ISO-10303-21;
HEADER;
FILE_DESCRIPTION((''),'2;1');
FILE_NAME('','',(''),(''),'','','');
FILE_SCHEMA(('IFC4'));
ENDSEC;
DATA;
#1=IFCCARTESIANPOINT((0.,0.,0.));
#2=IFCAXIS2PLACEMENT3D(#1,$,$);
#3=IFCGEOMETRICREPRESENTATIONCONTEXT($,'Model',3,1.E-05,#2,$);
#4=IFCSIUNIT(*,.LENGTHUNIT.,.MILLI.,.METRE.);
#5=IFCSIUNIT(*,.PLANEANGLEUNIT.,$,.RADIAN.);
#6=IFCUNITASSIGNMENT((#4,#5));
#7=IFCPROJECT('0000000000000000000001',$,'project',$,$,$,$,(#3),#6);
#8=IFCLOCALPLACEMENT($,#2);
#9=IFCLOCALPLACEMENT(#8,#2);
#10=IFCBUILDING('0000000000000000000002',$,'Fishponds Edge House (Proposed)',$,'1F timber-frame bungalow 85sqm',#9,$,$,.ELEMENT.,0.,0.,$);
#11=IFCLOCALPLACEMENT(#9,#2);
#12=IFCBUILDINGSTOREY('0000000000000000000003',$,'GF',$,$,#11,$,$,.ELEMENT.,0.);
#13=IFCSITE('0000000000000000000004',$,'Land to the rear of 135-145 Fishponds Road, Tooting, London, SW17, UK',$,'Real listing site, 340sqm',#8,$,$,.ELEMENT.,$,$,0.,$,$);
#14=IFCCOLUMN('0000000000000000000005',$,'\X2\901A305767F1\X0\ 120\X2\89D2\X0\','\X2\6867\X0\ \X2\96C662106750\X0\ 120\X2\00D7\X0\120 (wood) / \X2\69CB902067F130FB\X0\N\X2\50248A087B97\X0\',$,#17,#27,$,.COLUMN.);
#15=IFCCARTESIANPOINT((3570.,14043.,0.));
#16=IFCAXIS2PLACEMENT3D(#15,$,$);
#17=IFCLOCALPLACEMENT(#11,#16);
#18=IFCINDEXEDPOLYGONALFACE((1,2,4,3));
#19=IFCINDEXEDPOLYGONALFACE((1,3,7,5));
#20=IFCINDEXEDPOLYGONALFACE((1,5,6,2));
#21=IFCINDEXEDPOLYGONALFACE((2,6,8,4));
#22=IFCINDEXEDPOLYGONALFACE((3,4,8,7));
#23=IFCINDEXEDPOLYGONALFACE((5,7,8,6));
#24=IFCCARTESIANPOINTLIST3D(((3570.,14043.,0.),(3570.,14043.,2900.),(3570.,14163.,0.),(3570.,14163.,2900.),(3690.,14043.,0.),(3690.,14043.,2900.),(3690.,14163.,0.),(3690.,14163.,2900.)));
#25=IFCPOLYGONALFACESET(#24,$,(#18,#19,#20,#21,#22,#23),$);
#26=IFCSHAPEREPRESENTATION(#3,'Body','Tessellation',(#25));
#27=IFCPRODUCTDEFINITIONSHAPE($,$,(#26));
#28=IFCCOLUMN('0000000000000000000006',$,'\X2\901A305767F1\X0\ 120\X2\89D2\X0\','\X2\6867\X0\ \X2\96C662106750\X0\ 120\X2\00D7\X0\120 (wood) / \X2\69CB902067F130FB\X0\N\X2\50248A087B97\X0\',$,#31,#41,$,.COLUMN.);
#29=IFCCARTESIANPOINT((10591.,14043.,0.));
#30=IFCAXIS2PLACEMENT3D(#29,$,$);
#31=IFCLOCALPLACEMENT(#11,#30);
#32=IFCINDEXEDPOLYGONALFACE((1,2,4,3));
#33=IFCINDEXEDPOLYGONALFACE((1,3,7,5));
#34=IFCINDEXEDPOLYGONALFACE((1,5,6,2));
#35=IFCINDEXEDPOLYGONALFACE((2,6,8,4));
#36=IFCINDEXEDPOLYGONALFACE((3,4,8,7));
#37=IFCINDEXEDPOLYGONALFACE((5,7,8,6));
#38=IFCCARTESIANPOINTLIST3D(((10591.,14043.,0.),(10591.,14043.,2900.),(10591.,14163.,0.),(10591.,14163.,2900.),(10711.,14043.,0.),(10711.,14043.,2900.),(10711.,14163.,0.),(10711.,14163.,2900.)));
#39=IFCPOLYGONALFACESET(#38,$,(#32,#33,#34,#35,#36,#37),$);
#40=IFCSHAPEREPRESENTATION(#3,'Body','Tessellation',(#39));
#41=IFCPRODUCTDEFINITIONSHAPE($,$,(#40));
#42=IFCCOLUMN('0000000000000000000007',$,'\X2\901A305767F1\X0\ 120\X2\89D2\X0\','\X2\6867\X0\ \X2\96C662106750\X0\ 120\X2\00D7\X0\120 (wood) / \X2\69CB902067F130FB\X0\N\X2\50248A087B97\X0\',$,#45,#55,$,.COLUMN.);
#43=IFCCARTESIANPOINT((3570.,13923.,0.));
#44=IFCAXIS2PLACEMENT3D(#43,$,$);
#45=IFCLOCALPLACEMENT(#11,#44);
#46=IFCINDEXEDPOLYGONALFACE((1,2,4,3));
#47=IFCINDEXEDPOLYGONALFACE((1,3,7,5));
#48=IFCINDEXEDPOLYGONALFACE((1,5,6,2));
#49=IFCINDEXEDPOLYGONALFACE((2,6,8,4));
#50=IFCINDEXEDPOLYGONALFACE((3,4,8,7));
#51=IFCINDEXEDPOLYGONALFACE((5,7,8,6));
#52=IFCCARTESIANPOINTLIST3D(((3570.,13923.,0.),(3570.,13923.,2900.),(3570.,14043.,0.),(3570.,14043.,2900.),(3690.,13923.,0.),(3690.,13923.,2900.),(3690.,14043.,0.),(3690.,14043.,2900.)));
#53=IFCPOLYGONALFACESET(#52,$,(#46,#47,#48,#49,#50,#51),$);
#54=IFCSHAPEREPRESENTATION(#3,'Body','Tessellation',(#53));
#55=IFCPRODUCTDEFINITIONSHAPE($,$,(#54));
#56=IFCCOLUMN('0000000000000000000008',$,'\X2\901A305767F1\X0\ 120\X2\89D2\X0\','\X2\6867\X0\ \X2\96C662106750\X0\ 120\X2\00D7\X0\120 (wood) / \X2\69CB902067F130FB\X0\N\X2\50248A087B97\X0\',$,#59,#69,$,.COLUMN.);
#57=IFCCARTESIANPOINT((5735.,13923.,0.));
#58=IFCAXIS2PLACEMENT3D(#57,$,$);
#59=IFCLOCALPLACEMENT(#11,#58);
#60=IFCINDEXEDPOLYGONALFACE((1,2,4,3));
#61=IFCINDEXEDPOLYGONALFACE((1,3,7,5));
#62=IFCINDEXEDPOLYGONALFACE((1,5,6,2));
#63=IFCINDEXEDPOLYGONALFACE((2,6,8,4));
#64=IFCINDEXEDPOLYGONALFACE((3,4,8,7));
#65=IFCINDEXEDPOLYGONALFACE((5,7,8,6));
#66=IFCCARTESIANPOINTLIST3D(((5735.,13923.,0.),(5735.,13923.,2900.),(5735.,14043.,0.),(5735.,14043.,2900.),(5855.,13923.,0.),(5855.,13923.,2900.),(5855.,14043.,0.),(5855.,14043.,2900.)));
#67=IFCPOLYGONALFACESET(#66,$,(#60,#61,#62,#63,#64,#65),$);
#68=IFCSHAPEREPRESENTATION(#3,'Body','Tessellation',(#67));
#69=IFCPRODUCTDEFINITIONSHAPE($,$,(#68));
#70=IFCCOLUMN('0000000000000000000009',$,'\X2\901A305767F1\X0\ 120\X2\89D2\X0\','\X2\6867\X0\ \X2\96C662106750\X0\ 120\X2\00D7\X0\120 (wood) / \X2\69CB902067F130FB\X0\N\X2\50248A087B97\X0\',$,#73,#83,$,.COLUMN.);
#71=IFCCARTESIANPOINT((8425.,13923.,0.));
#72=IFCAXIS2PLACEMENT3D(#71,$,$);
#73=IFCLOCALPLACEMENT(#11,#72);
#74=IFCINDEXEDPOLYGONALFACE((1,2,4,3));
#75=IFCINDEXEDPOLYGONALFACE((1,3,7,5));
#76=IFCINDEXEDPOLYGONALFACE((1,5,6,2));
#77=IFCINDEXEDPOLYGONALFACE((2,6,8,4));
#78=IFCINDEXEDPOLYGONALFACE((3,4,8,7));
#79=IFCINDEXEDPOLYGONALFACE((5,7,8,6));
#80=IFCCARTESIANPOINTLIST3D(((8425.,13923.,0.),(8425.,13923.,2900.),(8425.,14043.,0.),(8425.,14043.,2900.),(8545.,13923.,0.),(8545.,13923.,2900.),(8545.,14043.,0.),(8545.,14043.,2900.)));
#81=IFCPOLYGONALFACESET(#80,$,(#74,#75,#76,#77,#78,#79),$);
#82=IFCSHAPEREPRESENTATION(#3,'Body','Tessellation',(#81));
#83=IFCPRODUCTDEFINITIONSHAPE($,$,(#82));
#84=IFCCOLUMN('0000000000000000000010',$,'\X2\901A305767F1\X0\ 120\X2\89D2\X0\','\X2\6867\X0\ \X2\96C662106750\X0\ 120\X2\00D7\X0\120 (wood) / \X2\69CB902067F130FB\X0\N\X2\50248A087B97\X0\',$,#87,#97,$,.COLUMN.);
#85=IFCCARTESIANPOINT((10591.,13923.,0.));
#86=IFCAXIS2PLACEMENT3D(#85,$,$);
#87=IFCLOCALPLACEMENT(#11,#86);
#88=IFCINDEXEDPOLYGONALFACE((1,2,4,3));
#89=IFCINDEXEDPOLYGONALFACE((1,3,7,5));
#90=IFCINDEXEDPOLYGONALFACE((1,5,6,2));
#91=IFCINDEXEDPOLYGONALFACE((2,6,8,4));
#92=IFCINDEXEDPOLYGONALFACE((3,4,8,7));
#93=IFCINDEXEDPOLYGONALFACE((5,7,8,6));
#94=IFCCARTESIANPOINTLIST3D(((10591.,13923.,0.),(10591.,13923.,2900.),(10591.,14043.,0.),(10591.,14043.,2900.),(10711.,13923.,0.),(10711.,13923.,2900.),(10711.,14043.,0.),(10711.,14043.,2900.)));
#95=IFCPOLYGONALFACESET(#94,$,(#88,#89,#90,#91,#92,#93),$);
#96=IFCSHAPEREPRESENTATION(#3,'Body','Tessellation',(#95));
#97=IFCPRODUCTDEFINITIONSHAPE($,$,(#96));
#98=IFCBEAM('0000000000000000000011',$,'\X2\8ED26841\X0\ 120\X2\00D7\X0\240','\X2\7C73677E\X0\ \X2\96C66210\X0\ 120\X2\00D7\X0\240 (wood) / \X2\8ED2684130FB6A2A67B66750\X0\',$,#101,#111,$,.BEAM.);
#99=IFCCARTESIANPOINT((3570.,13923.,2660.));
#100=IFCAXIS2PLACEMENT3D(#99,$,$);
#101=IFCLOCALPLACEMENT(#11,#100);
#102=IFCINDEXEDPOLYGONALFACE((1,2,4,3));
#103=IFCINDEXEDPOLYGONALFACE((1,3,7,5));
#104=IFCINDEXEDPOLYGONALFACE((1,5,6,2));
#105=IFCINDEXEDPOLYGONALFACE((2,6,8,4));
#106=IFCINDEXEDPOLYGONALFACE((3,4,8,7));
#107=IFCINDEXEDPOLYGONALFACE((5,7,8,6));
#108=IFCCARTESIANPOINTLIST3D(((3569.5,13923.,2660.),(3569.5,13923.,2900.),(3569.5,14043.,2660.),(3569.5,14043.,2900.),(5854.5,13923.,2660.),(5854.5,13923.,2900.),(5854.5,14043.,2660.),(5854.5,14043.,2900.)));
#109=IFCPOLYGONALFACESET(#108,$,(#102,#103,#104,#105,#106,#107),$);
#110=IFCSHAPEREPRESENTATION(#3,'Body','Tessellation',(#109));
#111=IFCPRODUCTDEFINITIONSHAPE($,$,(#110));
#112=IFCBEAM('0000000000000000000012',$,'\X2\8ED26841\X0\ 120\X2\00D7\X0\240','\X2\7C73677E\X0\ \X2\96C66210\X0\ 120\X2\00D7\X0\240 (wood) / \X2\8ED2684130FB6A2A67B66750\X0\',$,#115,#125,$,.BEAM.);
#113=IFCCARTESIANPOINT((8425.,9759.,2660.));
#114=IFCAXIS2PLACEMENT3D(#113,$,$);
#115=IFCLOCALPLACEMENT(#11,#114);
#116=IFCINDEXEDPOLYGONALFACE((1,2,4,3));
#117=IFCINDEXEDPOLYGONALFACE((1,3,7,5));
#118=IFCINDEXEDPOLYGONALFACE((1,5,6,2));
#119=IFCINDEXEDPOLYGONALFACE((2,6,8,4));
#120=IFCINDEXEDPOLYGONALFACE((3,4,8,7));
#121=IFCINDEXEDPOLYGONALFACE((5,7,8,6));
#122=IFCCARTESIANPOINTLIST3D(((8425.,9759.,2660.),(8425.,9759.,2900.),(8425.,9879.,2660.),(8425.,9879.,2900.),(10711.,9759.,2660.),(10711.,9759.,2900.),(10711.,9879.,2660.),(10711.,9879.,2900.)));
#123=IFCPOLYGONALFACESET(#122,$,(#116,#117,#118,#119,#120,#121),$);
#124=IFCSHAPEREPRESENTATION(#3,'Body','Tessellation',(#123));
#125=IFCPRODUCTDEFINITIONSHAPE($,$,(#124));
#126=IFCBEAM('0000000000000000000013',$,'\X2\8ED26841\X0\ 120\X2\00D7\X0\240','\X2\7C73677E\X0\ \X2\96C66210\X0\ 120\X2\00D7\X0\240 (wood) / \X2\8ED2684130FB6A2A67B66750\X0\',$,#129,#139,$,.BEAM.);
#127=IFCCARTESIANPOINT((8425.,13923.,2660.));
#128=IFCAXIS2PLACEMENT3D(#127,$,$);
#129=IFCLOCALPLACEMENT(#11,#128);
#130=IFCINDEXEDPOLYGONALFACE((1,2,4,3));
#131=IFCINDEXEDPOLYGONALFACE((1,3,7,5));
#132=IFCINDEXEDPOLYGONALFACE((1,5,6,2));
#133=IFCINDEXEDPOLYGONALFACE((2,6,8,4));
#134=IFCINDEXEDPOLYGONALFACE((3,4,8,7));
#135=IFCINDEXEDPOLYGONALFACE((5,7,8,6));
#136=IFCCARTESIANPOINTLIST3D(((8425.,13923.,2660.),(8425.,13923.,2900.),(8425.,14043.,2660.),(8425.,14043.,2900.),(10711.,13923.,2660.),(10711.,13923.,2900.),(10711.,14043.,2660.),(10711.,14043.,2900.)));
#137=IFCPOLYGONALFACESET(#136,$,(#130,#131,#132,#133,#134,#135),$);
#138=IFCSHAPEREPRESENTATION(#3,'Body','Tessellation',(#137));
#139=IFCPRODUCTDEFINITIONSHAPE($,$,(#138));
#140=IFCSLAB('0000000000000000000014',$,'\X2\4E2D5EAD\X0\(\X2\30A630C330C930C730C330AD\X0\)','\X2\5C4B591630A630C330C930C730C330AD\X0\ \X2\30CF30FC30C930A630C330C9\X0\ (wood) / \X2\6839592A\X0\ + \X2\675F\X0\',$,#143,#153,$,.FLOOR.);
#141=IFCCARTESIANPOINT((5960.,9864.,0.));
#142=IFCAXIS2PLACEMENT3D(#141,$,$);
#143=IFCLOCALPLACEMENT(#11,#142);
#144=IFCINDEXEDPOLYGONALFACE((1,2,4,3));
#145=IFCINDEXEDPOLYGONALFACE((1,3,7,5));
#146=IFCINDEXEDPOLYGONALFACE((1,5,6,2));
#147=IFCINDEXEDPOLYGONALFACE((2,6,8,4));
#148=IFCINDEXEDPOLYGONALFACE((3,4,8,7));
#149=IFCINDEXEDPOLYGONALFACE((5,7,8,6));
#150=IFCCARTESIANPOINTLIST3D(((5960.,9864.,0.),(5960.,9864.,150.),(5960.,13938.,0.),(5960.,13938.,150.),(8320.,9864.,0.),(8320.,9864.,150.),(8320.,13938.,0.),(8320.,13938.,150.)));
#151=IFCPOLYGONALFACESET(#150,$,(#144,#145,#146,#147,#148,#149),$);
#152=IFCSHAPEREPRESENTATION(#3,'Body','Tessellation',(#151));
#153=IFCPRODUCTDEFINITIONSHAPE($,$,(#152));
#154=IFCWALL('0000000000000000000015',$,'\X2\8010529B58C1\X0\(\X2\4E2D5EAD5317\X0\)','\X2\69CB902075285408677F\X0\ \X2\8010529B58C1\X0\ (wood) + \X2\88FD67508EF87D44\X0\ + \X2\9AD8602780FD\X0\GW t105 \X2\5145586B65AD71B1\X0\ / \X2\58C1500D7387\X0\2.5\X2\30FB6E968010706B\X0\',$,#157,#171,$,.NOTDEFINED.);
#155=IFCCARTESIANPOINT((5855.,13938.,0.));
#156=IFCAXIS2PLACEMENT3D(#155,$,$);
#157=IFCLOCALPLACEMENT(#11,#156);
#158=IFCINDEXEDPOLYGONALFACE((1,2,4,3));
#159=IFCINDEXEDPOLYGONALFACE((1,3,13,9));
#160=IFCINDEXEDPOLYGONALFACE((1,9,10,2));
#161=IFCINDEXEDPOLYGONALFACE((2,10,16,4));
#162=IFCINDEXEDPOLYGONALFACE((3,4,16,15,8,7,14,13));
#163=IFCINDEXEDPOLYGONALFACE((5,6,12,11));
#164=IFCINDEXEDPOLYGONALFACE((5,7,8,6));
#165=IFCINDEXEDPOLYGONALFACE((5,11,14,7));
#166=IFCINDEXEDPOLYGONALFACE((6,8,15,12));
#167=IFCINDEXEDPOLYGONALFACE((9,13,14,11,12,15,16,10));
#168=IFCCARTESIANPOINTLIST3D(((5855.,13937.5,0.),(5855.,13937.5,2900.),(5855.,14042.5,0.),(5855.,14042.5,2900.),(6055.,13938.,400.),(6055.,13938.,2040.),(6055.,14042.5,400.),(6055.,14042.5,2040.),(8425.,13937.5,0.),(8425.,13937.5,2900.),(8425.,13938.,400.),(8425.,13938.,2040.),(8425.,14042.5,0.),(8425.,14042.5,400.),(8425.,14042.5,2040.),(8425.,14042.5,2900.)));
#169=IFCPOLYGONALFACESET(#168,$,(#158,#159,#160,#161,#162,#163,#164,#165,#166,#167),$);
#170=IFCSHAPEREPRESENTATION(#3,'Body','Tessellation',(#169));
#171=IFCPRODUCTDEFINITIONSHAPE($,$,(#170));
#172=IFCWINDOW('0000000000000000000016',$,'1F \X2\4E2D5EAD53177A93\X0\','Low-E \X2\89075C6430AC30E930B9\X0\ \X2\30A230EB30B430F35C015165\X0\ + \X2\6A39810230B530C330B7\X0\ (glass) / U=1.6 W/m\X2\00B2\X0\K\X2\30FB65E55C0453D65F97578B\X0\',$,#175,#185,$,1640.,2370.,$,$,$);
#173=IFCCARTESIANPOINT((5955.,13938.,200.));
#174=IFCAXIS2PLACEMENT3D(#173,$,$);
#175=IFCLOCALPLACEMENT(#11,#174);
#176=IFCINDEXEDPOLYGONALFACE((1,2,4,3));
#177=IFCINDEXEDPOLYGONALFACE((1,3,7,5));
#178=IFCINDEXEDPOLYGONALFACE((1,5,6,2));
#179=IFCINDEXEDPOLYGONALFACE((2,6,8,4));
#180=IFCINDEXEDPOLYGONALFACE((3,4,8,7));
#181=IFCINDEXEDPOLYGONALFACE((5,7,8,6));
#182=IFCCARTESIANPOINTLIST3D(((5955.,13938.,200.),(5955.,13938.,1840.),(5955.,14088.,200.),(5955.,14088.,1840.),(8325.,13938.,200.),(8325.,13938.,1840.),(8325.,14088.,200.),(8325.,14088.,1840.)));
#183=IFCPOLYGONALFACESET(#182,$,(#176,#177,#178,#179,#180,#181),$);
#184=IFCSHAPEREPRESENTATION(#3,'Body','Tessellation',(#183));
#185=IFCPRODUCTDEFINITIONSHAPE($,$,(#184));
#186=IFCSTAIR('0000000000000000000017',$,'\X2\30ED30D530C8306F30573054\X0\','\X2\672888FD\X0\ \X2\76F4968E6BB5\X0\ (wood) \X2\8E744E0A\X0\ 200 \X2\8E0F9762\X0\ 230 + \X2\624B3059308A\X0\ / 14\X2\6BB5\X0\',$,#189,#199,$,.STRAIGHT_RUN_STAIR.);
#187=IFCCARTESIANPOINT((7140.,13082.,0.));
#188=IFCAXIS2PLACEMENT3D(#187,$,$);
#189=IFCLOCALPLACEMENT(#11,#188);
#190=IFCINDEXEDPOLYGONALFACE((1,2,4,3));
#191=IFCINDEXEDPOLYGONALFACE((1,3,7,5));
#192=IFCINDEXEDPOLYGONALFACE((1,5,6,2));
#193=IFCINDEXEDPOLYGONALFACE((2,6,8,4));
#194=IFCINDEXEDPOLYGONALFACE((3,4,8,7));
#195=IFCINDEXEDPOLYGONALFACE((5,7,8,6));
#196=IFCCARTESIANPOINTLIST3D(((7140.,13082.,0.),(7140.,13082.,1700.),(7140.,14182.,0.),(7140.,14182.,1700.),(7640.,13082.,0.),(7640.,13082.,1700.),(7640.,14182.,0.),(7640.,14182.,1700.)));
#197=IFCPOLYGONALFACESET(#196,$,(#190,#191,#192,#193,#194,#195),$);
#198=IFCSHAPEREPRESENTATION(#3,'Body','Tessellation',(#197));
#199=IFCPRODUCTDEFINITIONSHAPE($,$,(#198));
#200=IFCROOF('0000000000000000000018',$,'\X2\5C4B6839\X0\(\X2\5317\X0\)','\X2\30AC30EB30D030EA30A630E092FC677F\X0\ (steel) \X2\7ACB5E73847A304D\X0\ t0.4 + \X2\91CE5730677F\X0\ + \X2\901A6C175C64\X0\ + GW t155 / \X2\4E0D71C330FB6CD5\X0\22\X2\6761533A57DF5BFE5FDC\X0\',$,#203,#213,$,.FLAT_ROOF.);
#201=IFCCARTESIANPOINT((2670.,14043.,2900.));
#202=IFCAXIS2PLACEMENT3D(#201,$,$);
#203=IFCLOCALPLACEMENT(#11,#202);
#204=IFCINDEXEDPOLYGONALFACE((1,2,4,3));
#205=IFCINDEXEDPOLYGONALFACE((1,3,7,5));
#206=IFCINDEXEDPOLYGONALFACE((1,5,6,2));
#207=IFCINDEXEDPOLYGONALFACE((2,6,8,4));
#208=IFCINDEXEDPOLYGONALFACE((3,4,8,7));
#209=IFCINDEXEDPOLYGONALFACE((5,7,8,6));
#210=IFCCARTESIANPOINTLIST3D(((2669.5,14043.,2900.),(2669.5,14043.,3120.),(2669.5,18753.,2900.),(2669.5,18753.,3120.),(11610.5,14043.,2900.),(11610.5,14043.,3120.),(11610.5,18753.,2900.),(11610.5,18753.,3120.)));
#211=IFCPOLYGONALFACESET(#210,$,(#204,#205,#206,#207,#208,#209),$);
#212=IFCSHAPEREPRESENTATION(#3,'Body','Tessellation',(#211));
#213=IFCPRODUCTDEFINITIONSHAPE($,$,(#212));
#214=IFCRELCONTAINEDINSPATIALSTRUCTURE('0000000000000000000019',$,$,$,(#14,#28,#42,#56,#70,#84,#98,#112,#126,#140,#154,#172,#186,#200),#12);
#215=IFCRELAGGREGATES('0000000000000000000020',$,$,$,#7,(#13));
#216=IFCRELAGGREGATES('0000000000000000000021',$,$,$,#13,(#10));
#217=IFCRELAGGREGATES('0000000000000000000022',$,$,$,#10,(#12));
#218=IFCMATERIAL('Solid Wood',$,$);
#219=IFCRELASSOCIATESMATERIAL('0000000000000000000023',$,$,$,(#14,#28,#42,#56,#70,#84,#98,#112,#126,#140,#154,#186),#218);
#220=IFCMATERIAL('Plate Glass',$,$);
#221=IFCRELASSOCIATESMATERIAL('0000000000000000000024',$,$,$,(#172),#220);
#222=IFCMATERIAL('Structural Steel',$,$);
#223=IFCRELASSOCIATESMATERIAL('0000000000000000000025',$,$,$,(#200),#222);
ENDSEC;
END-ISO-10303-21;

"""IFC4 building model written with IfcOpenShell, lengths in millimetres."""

from ifc_helpers import new_model, si_unit, frame, frame_2d, origin, place, context, project, spatial, rectangle, extrude, material, element, fill, save


model = new_model("IFC4")

# Units and contexts
model_context = context("Model", 3, precision=1e-05, world=origin())
ifc_project = project(units=[si_unit("LENGTHUNIT", "METRE", prefix="MILLI"), si_unit("PLANEANGLEUNIT", "RADIAN")], contexts=[model_context])

# Site, building, storey
site_placement = place(None, origin())
site = spatial("IfcSite", under=ifc_project, at=site_placement, Name="Land to the rear of 135-145 Fishponds Road, Tooting, London, SW17, UK", ObjectType="Real listing site, 340sqm", CompositionType="ELEMENT", RefElevation=0.0)
building_placement = place(site_placement, origin())
building = spatial("IfcBuilding", under=site, at=building_placement, Name="Fishponds Edge House (Proposed)", ObjectType="1F timber-frame bungalow 85sqm", CompositionType="ELEMENT", ElevationOfRefHeight=0.0, ElevationOfTerrain=0.0)
storey_placement = place(building_placement, origin())
storey = spatial("IfcBuildingStorey", under=building, at=storey_placement, Name="GF", CompositionType="ELEMENT", Elevation=0.0)

# Columns
ifc_material_1 = material(Name="Solid Wood")
column_1_placement = place(storey_placement, frame((3570.0, 14043.0, 0.0)))
element("IfcColumn", 1, at=column_1_placement, inside=storey, material=ifc_material_1, Name="通し柱 120角", Description="桧 集成材 120×120 (wood) / 構造柱・N値計算", PredefinedType="COLUMN", context=model_context, shape_type="SweptSolid", body=[
    extrude(rectangle(XDim=120.0, YDim=120.0, at=frame_2d((60.0, 60.0))), frame((3570.0, 14043.0, 0.0)), (0.0, 0.0, 1.0), 2900.0),
])
column_2_placement = place(storey_placement, frame((10591.0, 14043.0, 0.0)))
element("IfcColumn", 2, at=column_2_placement, inside=storey, material=ifc_material_1, Name="通し柱 120角", Description="桧 集成材 120×120 (wood) / 構造柱・N値計算", PredefinedType="COLUMN", context=model_context, shape_type="SweptSolid", body=[
    extrude(rectangle(XDim=120.0, YDim=120.0, at=frame_2d((60.0, 60.0))), frame((10591.0, 14043.0, 0.0)), (0.0, 0.0, 1.0), 2900.0),
])
column_3_placement = place(storey_placement, frame((3570.0, 13923.0, 0.0)))
element("IfcColumn", 3, at=column_3_placement, inside=storey, material=ifc_material_1, Name="通し柱 120角", Description="桧 集成材 120×120 (wood) / 構造柱・N値計算", PredefinedType="COLUMN", context=model_context, shape_type="SweptSolid", body=[
    extrude(rectangle(XDim=120.0, YDim=120.0, at=frame_2d((60.0, 60.0))), frame((3570.0, 13923.0, 0.0)), (0.0, 0.0, 1.0), 2900.0),
])
column_4_placement = place(storey_placement, frame((5735.0, 13923.0, 0.0)))
element("IfcColumn", 4, at=column_4_placement, inside=storey, material=ifc_material_1, Name="通し柱 120角", Description="桧 集成材 120×120 (wood) / 構造柱・N値計算", PredefinedType="COLUMN", context=model_context, shape_type="SweptSolid", body=[
    extrude(rectangle(XDim=120.0, YDim=120.0, at=frame_2d((60.0, 60.0))), frame((5735.0, 13923.0, 0.0)), (0.0, 0.0, 1.0), 2900.0),
])
column_5_placement = place(storey_placement, frame((8425.0, 13923.0, 0.0)))
element("IfcColumn", 5, at=column_5_placement, inside=storey, material=ifc_material_1, Name="通し柱 120角", Description="桧 集成材 120×120 (wood) / 構造柱・N値計算", PredefinedType="COLUMN", context=model_context, shape_type="SweptSolid", body=[
    extrude(rectangle(XDim=120.0, YDim=120.0, at=frame_2d((60.0, 60.0))), frame((8425.0, 13923.0, 0.0)), (0.0, 0.0, 1.0), 2900.0),
])
column_6_placement = place(storey_placement, frame((10591.0, 13923.0, 0.0)))
element("IfcColumn", 6, at=column_6_placement, inside=storey, material=ifc_material_1, Name="通し柱 120角", Description="桧 集成材 120×120 (wood) / 構造柱・N値計算", PredefinedType="COLUMN", context=model_context, shape_type="SweptSolid", body=[
    extrude(rectangle(XDim=120.0, YDim=120.0, at=frame_2d((60.0, 60.0))), frame((10591.0, 13923.0, 0.0)), (0.0, 0.0, 1.0), 2900.0),
])

# Beams
beam_1_placement = place(storey_placement, frame((3570.0, 13923.0, 2660.0)))
element("IfcBeam", 7, at=beam_1_placement, inside=storey, material=ifc_material_1, Name="軒桁 120×240", Description="米松 集成 120×240 (wood) / 軒桁・横架材", PredefinedType="BEAM", context=model_context, shape_type="SweptSolid", body=[
    extrude(rectangle(XDim=2285.0, YDim=120.0, at=frame_2d((1142.0, 60.0))), frame((3570.0, 13923.0, 2660.0)), (0.0, 0.0, 1.0), 240.0),
])
beam_2_placement = place(storey_placement, frame((8425.0, 9759.0, 2660.0)))
element("IfcBeam", 8, at=beam_2_placement, inside=storey, material=ifc_material_1, Name="軒桁 120×240", Description="米松 集成 120×240 (wood) / 軒桁・横架材", PredefinedType="BEAM", context=model_context, shape_type="SweptSolid", body=[
    extrude(rectangle(XDim=2286.0, YDim=120.0, at=frame_2d((1143.0, 60.0))), frame((8425.0, 9759.0, 2660.0)), (0.0, 0.0, 1.0), 240.0),
])
beam_3_placement = place(storey_placement, frame((8425.0, 13923.0, 2660.0)))
element("IfcBeam", 9, at=beam_3_placement, inside=storey, material=ifc_material_1, Name="軒桁 120×240", Description="米松 集成 120×240 (wood) / 軒桁・横架材", PredefinedType="BEAM", context=model_context, shape_type="SweptSolid", body=[
    extrude(rectangle(XDim=2286.0, YDim=120.0, at=frame_2d((1143.0, 60.0))), frame((8425.0, 13923.0, 2660.0)), (0.0, 0.0, 1.0), 240.0),
])

# Slab
slab_1_placement = place(storey_placement, frame((5960.0, 9864.0, 0.0)))
element("IfcSlab", 10, at=slab_1_placement, inside=storey, material=ifc_material_1, Name="中庭(ウッドデッキ)", Description="屋外ウッドデッキ ハードウッド (wood) / 根太 + 束", PredefinedType="FLOOR", context=model_context, shape_type="SweptSolid", body=[
    extrude(rectangle(XDim=2360.0, YDim=4074.0, at=frame_2d((1180.0, 2037.0))), frame((5960.0, 9864.0, 0.0)), (0.0, 0.0, 1.0), 150.0),
])

# Wall, opening, window
wall_placement = place(storey_placement, frame((5855.0, 13938.0, 0.0)))
wall = element("IfcWall", 11, at=wall_placement, inside=storey, material=ifc_material_1, Name="耐力壁(中庭北)", Description="構造用合板 耐力壁 (wood) + 製材軸組 + 高性能GW t105 充填断熱 / 壁倍率2.5・準耐火", PredefinedType="NOTDEFINED", context=model_context, shape_type="SweptSolid", body=[
    extrude(rectangle(XDim=2570.0, YDim=105.0, at=frame_2d((1285.0, 52.0))), frame((5855.0, 13938.0, 0.0)), (0.0, 0.0, 1.0), 2900.0),
])
opening_placement = place(storey_placement, frame((5955.0, 13938.0, 200.0)))
opening = element("IfcOpeningElement", 12, at=opening_placement, cuts=wall, PredefinedType="NOTDEFINED", context=model_context, shape_type="SweptSolid", body=[
    extrude(rectangle(XDim=2370.0, YDim=150.0, at=frame_2d((1185.0, 75.0))), frame((5955.0, 13938.0, 200.0)), (0.0, 0.0, 1.0), 1640.0),
])
ifc_material_2 = material(Name="Plate Glass")
window_placement = place(storey_placement, frame((5955.0, 13938.0, 200.0)))
window = element("IfcWindow", 13, at=window_placement, inside=storey, material=ifc_material_2, Name="1F 中庭北窓", Description="Low-E 複層ガラス アルゴン封入 + 樹脂サッシ (glass) / U=1.6 W/m²K・日射取得型", OverallHeight=1640.0, OverallWidth=2370.0, context=model_context, shape_type="SweptSolid", body=[
    extrude(rectangle(XDim=2370.0, YDim=150.0, at=frame_2d((1185.0, 75.0))), frame((5955.0, 13938.0, 200.0)), (0.0, 0.0, 1.0), 1640.0),
])
fill(opening, window)

# Stair
stair_placement = place(storey_placement, frame((7140.0, 13082.0, 0.0)))
element("IfcStair", 14, at=stair_placement, inside=storey, material=ifc_material_1, Name="ロフトはしご", Description="木製 直階段 (wood) 蹴上 200 踏面 230 + 手すり / 14段", PredefinedType="STRAIGHT_RUN_STAIR", context=model_context, shape_type="SweptSolid", body=[
    extrude(rectangle(XDim=500.0, YDim=1100.0, at=frame_2d((250.0, 550.0))), frame((7140.0, 13082.0, 0.0)), (0.0, 0.0, 1.0), 1700.0),
])

# Roof
ifc_material_3 = material(Name="Structural Steel")
roof_placement = place(storey_placement, frame((2670.0, 14043.0, 2900.0)))
element("IfcRoof", 15, at=roof_placement, inside=storey, material=ifc_material_3, Name="屋根(北)", Description="ガルバリウム鋼板 (steel) 立平葺き t0.4 + 野地板 + 通気層 + GW t155 / 不燃・法22条区域対応", PredefinedType="FLAT_ROOF", context=model_context, shape_type="SweptSolid", body=[
    extrude(rectangle(XDim=8941.0, YDim=4710.0, at=frame_2d((4470.0, 2355.0))), frame((2670.0, 14043.0, 2900.0)), (0.0, 0.0, 1.0), 220.0),
])

save(model, "model.ifc")
